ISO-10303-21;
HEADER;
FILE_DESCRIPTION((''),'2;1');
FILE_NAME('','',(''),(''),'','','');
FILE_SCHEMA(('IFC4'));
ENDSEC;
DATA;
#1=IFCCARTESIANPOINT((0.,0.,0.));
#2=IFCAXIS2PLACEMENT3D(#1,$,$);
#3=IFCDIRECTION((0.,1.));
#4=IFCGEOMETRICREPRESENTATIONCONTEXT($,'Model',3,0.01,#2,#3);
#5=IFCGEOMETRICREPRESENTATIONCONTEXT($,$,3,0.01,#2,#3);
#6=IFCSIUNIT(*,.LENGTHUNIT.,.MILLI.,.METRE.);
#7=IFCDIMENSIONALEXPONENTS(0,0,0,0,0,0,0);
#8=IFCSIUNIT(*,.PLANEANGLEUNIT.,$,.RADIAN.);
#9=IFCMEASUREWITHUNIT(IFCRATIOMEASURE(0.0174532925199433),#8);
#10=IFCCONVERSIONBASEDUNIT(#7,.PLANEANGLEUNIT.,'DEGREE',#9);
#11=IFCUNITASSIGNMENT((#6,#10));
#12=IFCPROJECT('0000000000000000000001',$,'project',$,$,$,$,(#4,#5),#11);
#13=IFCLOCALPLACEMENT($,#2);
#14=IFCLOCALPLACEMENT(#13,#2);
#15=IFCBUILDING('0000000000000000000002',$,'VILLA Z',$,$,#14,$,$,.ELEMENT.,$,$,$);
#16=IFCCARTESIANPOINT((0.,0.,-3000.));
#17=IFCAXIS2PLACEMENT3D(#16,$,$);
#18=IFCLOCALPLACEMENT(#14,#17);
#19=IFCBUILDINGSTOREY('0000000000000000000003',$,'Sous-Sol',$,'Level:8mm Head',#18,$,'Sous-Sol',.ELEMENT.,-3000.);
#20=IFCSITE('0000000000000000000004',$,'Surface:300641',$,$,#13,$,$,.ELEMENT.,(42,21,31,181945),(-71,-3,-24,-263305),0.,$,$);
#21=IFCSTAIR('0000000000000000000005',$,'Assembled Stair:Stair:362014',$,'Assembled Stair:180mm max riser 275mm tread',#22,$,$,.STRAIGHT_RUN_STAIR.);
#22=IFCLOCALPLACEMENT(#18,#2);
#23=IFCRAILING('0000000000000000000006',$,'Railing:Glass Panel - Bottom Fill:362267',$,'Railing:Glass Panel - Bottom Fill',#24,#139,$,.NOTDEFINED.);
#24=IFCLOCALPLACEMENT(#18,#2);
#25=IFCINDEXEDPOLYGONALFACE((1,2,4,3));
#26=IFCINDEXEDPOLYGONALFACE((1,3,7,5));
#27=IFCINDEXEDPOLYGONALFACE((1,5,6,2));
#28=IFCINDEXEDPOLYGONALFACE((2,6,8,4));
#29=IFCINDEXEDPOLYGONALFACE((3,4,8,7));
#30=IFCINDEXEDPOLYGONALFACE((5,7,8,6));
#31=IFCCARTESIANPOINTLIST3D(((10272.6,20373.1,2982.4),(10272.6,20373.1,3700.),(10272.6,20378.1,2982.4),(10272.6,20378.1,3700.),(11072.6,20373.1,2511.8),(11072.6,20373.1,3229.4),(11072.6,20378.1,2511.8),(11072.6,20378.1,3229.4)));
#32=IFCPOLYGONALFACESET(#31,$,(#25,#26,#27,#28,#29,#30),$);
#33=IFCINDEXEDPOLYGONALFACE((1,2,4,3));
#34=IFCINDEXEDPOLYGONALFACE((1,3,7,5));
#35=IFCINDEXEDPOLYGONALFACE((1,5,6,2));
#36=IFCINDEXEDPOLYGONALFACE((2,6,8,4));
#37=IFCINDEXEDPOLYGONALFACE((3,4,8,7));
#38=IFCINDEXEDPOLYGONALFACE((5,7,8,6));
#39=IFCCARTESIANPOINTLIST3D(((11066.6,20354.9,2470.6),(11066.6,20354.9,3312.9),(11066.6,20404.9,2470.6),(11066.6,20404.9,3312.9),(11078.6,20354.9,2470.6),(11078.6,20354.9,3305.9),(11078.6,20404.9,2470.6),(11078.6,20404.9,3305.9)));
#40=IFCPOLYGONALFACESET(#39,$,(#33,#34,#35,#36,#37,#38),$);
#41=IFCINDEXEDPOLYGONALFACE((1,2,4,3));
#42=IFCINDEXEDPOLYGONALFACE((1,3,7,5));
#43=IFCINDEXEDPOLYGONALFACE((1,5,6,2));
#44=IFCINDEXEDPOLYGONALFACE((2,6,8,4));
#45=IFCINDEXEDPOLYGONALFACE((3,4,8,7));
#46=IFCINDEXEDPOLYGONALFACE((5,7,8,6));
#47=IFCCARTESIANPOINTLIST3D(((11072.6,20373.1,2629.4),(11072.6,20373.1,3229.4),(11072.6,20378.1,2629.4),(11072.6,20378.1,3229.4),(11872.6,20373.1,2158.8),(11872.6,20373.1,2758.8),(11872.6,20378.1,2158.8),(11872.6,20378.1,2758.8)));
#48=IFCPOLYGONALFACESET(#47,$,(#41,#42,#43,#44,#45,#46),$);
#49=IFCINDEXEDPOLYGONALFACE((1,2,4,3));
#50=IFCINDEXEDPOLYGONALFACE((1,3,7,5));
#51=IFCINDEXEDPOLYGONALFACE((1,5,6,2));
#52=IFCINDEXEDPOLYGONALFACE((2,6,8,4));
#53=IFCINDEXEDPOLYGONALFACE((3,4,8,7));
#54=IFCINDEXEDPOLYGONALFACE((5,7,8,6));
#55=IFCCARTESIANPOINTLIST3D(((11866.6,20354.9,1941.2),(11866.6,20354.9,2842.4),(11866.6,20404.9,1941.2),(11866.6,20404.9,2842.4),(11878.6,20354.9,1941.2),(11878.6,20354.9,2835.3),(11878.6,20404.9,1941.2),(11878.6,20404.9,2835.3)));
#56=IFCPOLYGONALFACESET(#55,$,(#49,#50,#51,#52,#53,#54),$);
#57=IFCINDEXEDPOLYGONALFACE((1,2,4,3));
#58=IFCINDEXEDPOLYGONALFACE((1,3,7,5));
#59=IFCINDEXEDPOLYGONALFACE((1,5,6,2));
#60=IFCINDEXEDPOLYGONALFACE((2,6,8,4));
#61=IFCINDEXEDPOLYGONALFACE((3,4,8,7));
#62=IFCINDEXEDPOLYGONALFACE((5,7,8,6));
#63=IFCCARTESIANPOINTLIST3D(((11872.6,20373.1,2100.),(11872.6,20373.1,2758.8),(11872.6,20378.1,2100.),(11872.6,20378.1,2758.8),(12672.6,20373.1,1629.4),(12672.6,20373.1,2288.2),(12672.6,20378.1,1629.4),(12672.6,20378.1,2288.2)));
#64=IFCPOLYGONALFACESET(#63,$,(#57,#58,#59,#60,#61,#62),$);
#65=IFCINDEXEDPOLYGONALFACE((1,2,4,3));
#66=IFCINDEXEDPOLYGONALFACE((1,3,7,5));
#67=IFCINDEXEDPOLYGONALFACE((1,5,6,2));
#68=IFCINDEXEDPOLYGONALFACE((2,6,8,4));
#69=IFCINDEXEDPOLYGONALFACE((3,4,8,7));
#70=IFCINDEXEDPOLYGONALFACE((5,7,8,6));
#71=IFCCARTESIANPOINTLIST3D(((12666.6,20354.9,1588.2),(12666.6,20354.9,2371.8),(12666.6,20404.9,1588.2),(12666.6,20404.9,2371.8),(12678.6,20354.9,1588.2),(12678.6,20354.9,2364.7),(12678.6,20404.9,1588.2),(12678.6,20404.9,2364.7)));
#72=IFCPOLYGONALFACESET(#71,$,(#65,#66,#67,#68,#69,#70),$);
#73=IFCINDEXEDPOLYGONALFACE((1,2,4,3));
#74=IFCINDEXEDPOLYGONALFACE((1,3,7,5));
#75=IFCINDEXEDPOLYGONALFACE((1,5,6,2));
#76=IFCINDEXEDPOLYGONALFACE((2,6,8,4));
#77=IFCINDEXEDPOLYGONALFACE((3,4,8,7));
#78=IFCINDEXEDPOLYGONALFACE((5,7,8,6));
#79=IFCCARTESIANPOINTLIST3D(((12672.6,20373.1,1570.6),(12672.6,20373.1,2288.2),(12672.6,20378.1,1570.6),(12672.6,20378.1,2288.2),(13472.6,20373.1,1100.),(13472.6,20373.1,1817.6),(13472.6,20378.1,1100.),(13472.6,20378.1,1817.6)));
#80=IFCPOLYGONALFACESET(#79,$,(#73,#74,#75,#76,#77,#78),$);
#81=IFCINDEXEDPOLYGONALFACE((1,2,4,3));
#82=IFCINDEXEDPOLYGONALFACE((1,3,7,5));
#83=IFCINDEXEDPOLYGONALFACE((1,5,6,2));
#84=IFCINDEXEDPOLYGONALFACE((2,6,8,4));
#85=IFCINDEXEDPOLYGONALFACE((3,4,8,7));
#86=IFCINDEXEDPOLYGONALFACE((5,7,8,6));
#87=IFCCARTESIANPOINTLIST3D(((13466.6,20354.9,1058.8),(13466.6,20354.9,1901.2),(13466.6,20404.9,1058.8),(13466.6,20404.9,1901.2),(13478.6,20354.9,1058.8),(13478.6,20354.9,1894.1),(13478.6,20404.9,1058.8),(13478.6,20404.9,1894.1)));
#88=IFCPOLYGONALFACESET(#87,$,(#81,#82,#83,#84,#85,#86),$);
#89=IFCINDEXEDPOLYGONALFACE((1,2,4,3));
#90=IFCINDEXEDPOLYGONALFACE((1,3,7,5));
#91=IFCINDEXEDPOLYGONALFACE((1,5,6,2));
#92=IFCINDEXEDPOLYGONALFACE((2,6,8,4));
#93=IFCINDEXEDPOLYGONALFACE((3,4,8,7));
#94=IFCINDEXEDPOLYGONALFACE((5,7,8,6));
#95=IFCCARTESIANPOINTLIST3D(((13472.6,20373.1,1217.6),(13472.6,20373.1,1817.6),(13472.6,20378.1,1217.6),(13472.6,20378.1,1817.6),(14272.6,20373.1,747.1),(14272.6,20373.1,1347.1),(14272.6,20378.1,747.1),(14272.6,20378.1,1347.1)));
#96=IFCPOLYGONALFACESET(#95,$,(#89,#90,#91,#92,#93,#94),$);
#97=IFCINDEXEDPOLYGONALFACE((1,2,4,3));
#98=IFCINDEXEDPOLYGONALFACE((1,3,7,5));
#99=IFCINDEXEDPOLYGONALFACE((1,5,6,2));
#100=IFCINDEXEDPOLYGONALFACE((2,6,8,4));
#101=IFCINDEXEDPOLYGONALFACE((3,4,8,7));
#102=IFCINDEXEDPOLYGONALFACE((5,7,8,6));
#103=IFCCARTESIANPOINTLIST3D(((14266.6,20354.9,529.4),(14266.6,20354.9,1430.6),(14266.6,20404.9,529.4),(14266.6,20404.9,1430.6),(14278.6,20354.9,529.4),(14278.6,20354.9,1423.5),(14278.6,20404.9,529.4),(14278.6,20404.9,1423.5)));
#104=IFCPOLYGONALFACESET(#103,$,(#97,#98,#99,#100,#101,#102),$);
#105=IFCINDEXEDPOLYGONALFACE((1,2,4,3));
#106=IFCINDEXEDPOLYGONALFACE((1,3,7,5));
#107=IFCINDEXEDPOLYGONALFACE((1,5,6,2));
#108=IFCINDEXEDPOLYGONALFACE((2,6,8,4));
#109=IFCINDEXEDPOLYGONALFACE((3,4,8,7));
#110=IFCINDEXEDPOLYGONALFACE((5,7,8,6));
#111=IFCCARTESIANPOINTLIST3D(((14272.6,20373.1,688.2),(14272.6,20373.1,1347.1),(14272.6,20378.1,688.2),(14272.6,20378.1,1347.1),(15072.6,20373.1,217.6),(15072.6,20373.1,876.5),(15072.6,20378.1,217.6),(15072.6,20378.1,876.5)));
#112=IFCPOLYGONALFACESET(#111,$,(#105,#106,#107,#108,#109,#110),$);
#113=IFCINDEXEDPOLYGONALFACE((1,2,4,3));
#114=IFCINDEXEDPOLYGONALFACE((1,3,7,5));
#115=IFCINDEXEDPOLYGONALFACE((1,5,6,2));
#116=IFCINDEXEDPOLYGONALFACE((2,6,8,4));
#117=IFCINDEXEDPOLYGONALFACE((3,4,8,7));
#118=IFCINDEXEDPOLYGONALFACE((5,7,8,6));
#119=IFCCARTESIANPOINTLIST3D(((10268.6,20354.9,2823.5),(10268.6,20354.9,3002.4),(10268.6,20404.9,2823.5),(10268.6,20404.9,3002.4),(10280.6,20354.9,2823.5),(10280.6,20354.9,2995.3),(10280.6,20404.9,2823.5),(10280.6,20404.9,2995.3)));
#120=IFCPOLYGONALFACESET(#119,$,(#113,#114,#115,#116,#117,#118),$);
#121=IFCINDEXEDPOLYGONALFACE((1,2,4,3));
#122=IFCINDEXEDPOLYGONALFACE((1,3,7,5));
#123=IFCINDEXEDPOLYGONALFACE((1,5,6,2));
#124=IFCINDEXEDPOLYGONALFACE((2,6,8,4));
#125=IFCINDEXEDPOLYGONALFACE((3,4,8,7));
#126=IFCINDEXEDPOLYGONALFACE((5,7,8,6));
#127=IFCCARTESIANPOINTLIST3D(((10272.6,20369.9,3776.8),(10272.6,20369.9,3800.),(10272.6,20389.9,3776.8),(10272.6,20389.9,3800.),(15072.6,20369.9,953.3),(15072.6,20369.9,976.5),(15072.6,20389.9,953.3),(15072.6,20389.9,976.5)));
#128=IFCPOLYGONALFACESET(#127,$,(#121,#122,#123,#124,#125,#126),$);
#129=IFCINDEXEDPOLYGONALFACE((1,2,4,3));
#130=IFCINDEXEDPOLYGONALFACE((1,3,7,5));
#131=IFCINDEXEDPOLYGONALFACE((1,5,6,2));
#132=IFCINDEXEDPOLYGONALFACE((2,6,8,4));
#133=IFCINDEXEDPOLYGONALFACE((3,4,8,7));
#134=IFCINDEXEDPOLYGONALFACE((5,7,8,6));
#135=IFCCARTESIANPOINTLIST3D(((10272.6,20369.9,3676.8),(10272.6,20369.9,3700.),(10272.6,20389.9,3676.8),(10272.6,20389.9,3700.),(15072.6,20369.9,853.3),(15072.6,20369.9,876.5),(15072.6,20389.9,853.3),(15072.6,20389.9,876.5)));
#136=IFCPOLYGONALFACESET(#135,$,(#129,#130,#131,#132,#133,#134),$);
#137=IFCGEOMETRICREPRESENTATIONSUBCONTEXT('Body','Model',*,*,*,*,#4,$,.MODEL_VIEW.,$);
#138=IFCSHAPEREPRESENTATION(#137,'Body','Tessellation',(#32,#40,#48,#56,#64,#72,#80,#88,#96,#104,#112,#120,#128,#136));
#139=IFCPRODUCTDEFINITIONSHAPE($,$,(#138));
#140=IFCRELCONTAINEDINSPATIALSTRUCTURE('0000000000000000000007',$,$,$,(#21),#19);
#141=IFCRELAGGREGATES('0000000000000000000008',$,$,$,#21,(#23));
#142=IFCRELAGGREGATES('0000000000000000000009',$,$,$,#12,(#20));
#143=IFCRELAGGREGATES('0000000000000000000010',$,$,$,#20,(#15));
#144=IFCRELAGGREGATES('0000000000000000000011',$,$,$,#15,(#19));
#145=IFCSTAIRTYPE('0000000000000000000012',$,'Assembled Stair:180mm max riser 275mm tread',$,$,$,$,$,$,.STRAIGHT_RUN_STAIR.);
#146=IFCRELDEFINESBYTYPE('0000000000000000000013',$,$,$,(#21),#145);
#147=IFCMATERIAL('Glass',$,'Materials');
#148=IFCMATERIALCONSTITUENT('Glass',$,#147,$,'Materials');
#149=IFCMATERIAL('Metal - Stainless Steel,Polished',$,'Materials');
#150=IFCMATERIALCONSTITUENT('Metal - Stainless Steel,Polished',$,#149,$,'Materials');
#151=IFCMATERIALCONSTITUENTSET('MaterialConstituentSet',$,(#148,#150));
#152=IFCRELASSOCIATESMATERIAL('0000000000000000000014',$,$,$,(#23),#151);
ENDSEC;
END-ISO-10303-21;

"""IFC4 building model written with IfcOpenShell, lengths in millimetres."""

from ifc_helpers import new_model, entity, si_unit, converted_unit, direction, frame, origin, place, context, subcontext, project, spatial, polyline, outline, extrude, material, constituent, constituent_set, type_object, element, aggregate, save


model = new_model("IFC4")

# Units and contexts
model_context = context("Model", 3, precision=0.01, world=origin(), true_north=direction((0.0, 1.0)))
context_of_model = context(None, 3, precision=0.01, world=origin(), true_north=direction((0.0, 1.0)))
body_context = subcontext(model_context, "Body", "Model", "MODEL_VIEW")
ifc_project = project(units=[si_unit("LENGTHUNIT", "METRE", prefix="MILLI"), converted_unit("PLANEANGLEUNIT", "DEGREE", entity("IfcRatioMeasure", 0.0174532925199433), si_unit("PLANEANGLEUNIT", "RADIAN"), dimensions=[0, 0, 0, 0, 0, 0, 0])], contexts=[model_context, context_of_model])

# Site, building, storey
site_placement = place(None, origin())
site = spatial("IfcSite", under=ifc_project, at=site_placement, Name="Surface:300641", CompositionType="ELEMENT", RefLatitude=(42, 21, 31, 181945), RefLongitude=(-71, -3, -24, -263305), RefElevation=0.0)
building_placement = place(site_placement, origin())
building = spatial("IfcBuilding", under=site, at=building_placement, Name="VILLA Z", CompositionType="ELEMENT")
storey_placement = place(building_placement, frame((0.0, 0.0, -3000.0)))
storey = spatial("IfcBuildingStorey", under=building, at=storey_placement, Name="Sous-Sol", ObjectType="Level:8mm Head", LongName="Sous-Sol", CompositionType="ELEMENT", Elevation=-3000.0)

# Stair
stair_type = type_object("IfcStairType", Name="Assembled Stair:180mm max riser 275mm tread", PredefinedType="STRAIGHT_RUN_STAIR")
stair_placement = place(storey_placement, origin())
stair = element("IfcStair", 1, at=stair_placement, inside=storey, type_object=stair_type, Name="Assembled Stair:Stair:362014", ObjectType="Assembled Stair:180mm max riser 275mm tread", PredefinedType="STRAIGHT_RUN_STAIR")

# Shared definitions
ifc_material_1 = material(Name="Glass", Category="Materials")

# Railing
ifc_material_2 = material(Name="Metal - Stainless Steel,Polished", Category="Materials")
ifc_constituent_1 = constituent(ifc_material_1, Name="Glass", Category="Materials")
ifc_constituent_2 = constituent(ifc_material_2, Name="Metal - Stainless Steel,Polished", Category="Materials")
ifc_constituent_set_1 = constituent_set(constituents=[ifc_constituent_1, ifc_constituent_2], Name="MaterialConstituentSet")
railing_1_placement = place(stair_placement, frame((10268.6, 20354.9, 217.6)))
railing_1 = element("IfcRailing", 2, at=railing_1_placement, material=ifc_constituent_set_1, Name="Railing:Glass Panel - Bottom Fill:362267", ObjectType="Railing:Glass Panel - Bottom Fill", PredefinedType="NOTDEFINED", context=body_context, shape_type="SweptSolid", body=[
    extrude(outline(polyline([(-123.5, -400.0), (594.1, -400.0), (123.5, 400.0), (-594.1, 400.0), (-123.5, -400.0)])), frame((404.0, 18.3, 2888.2), z_axis=(0.0, 1.0, 0.0), x_axis=(0.0, 0.0, -1.0)), (0.0, 0.0, 1.0), 5.0),
    extrude(outline(polyline([(-419.4, -6.0), (422.9, -6.0), (415.9, 6.0), (-419.4, 6.0), (-419.4, -6.0)])), frame((804.0, 0.0, 2672.4), z_axis=(0.0, 1.0, 0.0), x_axis=(0.0, 0.0, 1.0)), (0.0, 0.0, 1.0), 50.0),
    extrude(outline(polyline([(-64.7, -400.0), (535.3, -400.0), (64.7, 400.0), (-535.3, 400.0), (-64.7, -400.0)])), frame((1204.0, 18.3, 2476.5), z_axis=(0.0, 1.0, 0.0), x_axis=(0.0, 0.0, -1.0)), (0.0, 0.0, 1.0), 5.0),
    extrude(outline(polyline([(-448.8, -6.0), (452.4, -6.0), (445.3, 6.0), (-448.8, 6.0), (-448.8, -6.0)])), frame((1604.0, 0.0, 2172.4), z_axis=(0.0, 1.0, 0.0), x_axis=(0.0, 0.0, 1.0)), (0.0, 0.0, 1.0), 50.0),
    extrude(outline(polyline([(-94.1, -400.0), (564.7, -400.0), (94.1, 400.0), (-564.7, 400.0), (-94.1, -400.0)])), frame((2004.0, 18.3, 1976.5), z_axis=(0.0, 1.0, 0.0), x_axis=(0.0, 0.0, -1.0)), (0.0, 0.0, 1.0), 5.0),
    extrude(outline(polyline([(-390.0, -6.0), (393.5, -6.0), (386.5, 6.0), (-390.0, 6.0), (-390.0, -6.0)])), frame((2404.0, 0.0, 1760.6), z_axis=(0.0, 1.0, 0.0), x_axis=(0.0, 0.0, 1.0)), (0.0, 0.0, 1.0), 50.0),
    extrude(outline(polyline([(-123.5, -400.0), (594.1, -400.0), (123.5, 400.0), (-594.1, 400.0), (-123.5, -400.0)])), frame((2804.0, 18.3, 1476.5), z_axis=(0.0, 1.0, 0.0), x_axis=(0.0, 0.0, -1.0)), (0.0, 0.0, 1.0), 5.0),
    extrude(outline(polyline([(-419.4, -6.0), (422.9, -6.0), (415.9, 6.0), (-419.4, 6.0), (-419.4, -6.0)])), frame((3204.0, 0.0, 1260.6), z_axis=(0.0, 1.0, 0.0), x_axis=(0.0, 0.0, 1.0)), (0.0, 0.0, 1.0), 50.0),
    extrude(outline(polyline([(-64.7, -400.0), (535.3, -400.0), (64.7, 400.0), (-535.3, 400.0), (-64.7, -400.0)])), frame((3604.0, 18.3, 1064.7), z_axis=(0.0, 1.0, 0.0), x_axis=(0.0, 0.0, -1.0)), (0.0, 0.0, 1.0), 5.0),
    extrude(outline(polyline([(-448.8, -6.0), (452.4, -6.0), (445.3, 6.0), (-448.8, 6.0), (-448.8, -6.0)])), frame((4004.0, 0.0, 760.6), z_axis=(0.0, 1.0, 0.0), x_axis=(0.0, 0.0, 1.0)), (0.0, 0.0, 1.0), 50.0),
    extrude(outline(polyline([(-94.1, -400.0), (564.7, -400.0), (94.1, 400.0), (-564.7, 400.0), (-94.1, -400.0)])), frame((4404.0, 18.3, 564.7), z_axis=(0.0, 1.0, 0.0), x_axis=(0.0, 0.0, -1.0)), (0.0, 0.0, 1.0), 5.0),
    extrude(outline(polyline([(-87.6, -6.0), (91.2, -6.0), (84.1, 6.0), (-87.6, 6.0), (-87.6, -6.0)])), frame((6.0, 0.0, 2693.5), z_axis=(0.0, 1.0, 0.0), x_axis=(0.0, 0.0, 1.0)), (0.0, 0.0, 1.0), 50.0),
    extrude(outline(polyline([(-2790.3, -10.0), (2778.6, -10.0), (2790.3, 10.0), (-2778.6, 10.0), (-2790.3, -10.0)])), frame((2404.0, 15.0, 2159.0), z_axis=(0.0, 1.0, 0.0), x_axis=(-0.861934, 0.0, 0.50702)), (0.0, 0.0, 1.0), 20.0),
    extrude(outline(polyline([(-2790.3, -10.0), (2778.6, -10.0), (2790.3, 10.0), (-2778.6, 10.0), (-2790.3, -10.0)])), frame((2404.0, 15.0, 2059.0), z_axis=(0.0, 1.0, 0.0), x_axis=(-0.861934, 0.0, 0.50702)), (0.0, 0.0, 1.0), 20.0),
])
aggregate(stair, [railing_1])

save(model, "model.ifc")
